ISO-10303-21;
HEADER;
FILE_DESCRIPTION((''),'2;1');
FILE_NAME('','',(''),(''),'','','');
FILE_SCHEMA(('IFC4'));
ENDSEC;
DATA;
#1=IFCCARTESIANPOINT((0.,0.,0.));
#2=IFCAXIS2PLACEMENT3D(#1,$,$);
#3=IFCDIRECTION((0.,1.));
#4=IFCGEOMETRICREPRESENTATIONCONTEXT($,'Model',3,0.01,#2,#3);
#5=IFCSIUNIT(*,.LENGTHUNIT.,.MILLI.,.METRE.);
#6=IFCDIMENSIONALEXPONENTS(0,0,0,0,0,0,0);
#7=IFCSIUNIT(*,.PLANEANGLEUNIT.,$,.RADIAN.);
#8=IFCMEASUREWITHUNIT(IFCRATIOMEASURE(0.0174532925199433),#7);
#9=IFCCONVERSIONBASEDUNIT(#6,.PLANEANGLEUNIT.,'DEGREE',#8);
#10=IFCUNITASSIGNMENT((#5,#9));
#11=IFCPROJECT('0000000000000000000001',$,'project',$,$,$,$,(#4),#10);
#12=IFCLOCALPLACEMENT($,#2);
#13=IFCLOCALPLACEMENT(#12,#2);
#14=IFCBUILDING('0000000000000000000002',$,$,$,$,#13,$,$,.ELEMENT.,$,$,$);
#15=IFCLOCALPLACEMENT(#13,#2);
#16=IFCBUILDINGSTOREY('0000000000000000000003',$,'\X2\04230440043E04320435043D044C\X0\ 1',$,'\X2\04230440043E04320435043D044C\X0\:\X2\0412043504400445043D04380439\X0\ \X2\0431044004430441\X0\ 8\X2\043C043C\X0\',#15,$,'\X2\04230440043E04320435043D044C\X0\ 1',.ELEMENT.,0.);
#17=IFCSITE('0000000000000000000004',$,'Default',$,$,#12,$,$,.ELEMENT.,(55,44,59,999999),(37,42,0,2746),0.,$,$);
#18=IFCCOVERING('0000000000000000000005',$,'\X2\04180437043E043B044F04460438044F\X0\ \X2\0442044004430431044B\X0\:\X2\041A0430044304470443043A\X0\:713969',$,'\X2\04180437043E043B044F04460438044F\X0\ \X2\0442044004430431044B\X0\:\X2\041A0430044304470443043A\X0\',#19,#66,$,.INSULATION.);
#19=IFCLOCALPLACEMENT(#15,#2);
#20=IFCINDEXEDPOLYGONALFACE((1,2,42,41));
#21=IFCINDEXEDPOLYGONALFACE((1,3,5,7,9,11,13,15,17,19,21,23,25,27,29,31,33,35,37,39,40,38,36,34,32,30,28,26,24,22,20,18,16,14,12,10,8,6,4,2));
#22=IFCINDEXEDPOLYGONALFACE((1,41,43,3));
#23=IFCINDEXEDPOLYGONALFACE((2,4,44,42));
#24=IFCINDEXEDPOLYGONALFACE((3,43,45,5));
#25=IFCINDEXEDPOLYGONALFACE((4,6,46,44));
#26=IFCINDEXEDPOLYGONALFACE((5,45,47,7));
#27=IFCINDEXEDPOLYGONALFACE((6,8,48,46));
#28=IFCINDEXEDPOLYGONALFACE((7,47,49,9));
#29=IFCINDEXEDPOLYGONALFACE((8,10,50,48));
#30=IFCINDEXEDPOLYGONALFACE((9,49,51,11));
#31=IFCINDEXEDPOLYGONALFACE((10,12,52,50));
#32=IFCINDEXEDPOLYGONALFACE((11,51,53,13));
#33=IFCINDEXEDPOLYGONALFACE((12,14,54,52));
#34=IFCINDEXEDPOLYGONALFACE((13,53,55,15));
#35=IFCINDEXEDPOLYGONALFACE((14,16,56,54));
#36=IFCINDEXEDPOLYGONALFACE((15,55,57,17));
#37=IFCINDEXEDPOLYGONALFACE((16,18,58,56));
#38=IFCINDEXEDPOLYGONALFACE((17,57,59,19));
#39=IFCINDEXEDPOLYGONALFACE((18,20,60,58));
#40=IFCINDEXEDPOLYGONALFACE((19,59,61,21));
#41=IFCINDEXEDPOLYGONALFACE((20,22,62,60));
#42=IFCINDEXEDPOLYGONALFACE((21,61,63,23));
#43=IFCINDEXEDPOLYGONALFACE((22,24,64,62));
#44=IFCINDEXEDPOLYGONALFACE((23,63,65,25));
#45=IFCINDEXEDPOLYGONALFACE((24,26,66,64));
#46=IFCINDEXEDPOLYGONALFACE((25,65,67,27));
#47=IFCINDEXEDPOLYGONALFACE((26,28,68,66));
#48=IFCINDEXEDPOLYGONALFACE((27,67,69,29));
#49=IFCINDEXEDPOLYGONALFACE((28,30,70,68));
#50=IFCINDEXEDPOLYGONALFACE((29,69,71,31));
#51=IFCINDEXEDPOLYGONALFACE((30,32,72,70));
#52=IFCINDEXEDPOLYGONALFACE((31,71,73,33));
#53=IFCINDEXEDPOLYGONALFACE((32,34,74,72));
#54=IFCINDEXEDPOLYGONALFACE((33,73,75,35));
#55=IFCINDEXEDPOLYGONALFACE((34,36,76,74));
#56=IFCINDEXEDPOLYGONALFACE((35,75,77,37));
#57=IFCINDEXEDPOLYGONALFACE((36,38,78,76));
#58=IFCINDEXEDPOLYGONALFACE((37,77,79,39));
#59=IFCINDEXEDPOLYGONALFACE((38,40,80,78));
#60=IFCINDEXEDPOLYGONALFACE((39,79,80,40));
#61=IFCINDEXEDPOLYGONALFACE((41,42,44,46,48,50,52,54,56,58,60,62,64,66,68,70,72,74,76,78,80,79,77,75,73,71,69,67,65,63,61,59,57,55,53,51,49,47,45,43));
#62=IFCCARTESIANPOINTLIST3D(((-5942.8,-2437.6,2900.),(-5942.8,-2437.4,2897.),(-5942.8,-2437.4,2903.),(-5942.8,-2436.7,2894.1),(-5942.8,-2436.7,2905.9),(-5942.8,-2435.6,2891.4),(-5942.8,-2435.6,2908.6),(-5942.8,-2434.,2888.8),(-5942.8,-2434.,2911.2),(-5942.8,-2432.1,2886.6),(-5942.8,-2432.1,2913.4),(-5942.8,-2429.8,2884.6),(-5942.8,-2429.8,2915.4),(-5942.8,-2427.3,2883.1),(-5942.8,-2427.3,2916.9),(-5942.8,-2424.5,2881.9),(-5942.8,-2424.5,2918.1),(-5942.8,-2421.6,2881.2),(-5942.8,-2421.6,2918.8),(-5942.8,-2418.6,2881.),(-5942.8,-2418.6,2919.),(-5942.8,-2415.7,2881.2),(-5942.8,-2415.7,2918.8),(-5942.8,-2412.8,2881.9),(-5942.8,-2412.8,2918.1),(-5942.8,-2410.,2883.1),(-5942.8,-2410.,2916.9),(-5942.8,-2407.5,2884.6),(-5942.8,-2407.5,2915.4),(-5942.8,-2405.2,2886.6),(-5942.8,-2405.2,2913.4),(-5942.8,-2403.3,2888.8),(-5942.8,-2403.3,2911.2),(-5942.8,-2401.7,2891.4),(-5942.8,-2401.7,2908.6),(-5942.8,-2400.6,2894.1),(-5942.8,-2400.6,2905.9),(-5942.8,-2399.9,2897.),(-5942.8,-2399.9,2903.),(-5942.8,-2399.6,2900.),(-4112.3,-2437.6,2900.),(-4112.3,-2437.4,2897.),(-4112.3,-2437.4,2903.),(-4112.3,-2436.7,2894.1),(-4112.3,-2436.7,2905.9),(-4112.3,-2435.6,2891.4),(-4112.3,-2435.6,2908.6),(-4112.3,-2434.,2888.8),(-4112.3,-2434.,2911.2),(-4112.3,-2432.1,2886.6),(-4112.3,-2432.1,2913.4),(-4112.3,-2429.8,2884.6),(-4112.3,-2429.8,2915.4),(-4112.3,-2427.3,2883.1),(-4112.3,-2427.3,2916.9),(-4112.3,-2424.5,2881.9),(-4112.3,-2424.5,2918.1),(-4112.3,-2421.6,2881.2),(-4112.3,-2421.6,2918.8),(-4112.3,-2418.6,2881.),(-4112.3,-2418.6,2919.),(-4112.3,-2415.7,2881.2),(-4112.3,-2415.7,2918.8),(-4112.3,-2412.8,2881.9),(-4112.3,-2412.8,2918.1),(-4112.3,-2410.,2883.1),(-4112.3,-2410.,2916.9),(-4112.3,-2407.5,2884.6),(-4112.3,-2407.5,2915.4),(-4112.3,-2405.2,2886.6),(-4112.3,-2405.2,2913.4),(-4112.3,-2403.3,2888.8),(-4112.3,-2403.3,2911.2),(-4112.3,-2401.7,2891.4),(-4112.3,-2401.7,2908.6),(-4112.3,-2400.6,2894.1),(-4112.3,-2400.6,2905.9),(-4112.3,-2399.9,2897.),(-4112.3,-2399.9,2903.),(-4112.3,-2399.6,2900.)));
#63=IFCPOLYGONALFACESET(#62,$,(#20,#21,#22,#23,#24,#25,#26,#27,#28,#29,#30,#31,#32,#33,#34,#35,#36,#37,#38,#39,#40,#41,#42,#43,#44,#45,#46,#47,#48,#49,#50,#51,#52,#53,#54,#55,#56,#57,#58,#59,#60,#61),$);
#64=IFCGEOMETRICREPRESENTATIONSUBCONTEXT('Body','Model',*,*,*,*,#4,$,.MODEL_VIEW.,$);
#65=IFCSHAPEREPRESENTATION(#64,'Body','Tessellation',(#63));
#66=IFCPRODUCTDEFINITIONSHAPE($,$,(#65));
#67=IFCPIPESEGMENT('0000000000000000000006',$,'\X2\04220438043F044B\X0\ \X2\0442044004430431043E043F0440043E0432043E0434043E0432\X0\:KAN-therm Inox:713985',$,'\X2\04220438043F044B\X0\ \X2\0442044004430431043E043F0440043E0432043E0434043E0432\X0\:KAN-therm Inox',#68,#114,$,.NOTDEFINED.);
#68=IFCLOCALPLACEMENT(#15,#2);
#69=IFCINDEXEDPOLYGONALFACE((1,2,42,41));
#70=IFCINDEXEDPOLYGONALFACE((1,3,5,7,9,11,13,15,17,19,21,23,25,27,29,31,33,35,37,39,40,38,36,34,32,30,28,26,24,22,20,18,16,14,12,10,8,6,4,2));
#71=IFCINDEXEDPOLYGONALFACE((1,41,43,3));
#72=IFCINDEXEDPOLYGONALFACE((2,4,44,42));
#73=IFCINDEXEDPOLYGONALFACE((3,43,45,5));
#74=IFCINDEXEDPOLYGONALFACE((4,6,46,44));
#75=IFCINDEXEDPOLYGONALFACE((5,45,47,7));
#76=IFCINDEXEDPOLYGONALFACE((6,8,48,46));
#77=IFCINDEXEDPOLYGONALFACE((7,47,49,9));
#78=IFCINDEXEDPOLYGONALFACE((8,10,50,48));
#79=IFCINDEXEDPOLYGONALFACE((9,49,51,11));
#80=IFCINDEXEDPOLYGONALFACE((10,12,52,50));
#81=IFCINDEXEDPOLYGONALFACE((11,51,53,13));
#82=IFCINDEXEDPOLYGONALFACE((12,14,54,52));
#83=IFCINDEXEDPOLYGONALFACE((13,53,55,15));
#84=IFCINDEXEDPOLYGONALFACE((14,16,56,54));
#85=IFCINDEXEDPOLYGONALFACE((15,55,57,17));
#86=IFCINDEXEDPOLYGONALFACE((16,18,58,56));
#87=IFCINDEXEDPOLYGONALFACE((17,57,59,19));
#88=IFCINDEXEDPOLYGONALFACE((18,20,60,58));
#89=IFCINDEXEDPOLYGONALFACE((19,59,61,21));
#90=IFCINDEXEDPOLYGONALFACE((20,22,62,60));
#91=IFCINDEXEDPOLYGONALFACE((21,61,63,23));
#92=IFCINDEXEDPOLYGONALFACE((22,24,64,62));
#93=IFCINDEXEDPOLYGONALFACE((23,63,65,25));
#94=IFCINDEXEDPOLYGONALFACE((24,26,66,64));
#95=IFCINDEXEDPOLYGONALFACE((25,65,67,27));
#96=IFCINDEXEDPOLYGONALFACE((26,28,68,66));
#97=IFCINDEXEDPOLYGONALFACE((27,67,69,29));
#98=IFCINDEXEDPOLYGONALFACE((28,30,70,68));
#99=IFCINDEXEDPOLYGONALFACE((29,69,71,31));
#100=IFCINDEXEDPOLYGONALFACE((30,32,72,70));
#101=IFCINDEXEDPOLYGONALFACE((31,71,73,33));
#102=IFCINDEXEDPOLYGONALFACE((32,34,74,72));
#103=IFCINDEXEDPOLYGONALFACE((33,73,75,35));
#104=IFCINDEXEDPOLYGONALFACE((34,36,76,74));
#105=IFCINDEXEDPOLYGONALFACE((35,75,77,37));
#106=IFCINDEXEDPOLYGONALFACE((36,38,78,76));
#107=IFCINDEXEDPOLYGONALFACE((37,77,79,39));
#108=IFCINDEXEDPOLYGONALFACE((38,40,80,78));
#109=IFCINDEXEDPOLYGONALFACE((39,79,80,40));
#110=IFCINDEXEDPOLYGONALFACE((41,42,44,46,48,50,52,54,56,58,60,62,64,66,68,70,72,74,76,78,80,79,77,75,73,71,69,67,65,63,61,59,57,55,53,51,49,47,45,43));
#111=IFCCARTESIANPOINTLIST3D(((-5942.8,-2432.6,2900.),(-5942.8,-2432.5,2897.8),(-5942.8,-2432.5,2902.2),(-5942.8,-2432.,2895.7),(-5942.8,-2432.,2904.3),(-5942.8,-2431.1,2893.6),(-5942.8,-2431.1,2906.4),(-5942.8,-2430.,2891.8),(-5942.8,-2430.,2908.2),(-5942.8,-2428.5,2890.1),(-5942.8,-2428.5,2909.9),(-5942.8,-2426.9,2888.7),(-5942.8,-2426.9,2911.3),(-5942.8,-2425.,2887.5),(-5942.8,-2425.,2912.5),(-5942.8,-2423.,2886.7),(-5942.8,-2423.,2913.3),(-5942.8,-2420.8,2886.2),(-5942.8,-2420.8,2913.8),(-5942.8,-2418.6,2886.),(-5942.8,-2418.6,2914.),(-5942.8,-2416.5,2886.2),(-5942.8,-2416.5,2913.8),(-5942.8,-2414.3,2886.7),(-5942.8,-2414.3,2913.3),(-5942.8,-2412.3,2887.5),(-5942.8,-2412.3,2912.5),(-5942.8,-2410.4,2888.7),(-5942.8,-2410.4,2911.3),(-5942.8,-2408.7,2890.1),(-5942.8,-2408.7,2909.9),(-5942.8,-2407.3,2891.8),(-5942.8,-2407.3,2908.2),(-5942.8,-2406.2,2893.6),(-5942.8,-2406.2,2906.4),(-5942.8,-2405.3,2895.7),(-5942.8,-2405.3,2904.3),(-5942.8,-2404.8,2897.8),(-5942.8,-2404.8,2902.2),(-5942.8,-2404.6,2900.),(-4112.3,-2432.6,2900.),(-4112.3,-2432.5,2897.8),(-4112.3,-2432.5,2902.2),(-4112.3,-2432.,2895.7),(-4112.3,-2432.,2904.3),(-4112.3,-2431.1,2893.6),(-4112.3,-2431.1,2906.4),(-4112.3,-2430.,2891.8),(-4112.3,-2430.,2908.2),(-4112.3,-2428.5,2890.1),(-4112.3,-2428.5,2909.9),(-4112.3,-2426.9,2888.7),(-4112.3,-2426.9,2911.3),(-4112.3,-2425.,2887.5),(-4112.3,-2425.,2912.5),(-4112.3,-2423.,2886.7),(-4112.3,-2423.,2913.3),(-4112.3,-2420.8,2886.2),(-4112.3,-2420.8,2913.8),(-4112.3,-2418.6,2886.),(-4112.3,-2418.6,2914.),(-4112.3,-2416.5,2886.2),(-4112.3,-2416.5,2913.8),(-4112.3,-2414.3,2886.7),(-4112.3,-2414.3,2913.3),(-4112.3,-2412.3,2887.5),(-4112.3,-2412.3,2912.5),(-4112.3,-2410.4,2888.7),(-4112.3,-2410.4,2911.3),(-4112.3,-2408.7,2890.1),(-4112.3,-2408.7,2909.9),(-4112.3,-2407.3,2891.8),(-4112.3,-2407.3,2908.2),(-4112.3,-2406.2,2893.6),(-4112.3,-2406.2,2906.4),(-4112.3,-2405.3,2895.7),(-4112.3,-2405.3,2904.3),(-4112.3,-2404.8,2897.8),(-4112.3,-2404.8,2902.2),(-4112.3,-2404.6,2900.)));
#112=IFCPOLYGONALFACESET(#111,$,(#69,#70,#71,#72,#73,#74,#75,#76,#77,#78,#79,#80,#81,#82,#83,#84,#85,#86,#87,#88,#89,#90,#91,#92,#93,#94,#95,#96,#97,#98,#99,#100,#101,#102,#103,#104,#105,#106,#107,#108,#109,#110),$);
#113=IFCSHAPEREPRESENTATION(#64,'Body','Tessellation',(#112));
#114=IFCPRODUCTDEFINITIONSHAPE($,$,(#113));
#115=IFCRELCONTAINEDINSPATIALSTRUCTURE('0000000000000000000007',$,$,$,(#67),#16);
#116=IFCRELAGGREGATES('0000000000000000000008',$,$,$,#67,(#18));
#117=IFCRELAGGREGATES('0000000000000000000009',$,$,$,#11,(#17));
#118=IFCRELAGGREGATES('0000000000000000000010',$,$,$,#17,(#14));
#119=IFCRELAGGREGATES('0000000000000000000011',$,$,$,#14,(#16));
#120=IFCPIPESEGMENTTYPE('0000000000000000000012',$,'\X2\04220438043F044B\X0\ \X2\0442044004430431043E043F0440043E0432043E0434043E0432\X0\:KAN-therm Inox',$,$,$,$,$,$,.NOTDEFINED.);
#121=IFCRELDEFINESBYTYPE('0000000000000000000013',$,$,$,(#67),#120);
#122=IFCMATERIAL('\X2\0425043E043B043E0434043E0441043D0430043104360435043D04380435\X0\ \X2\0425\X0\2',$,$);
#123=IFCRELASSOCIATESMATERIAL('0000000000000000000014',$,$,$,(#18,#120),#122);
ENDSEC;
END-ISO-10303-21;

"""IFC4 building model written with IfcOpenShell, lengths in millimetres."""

from ifc_helpers import new_model, entity, si_unit, converted_unit, direction, frame, origin, place, context, subcontext, project, spatial, indexed_curve, outline, extrude, material, type_object, element, aggregate, save


model = new_model("IFC4")

# Units and contexts
model_context = context("Model", 3, precision=0.01, world=origin(), true_north=direction((0.0, 1.0)))
body_context = subcontext(model_context, "Body", "Model", "MODEL_VIEW")
ifc_project = project(units=[si_unit("LENGTHUNIT", "METRE", prefix="MILLI"), converted_unit("PLANEANGLEUNIT", "DEGREE", entity("IfcRatioMeasure", 0.0174532925199433), si_unit("PLANEANGLEUNIT", "RADIAN"), dimensions=[0, 0, 0, 0, 0, 0, 0])], contexts=[model_context])

# Site, building, storey
site_placement = place(None, origin())
site = spatial("IfcSite", under=ifc_project, at=site_placement, Name="Default", CompositionType="ELEMENT", RefLatitude=(55, 44, 59, 999999), RefLongitude=(37, 42, 0, 2746), RefElevation=0.0)
building_placement = place(site_placement, origin())
building = spatial("IfcBuilding", under=site, at=building_placement, CompositionType="ELEMENT")
storey_placement = place(building_placement, origin())
storey = spatial("IfcBuildingStorey", under=building, at=storey_placement, Name="Уровень 1", ObjectType="Уровень:Верхний брус 8мм", LongName="Уровень 1", CompositionType="ELEMENT", Elevation=0.0)

# Covering
ifc_material_1 = material(Name="Холодоснабжение Х2")
covering_1_placement = place(storey_placement, origin())
covering_1 = element("IfcCovering", 1, at=covering_1_placement, material=ifc_material_1, Name="Изоляция трубы:Каучук:713969", ObjectType="Изоляция трубы:Каучук", PredefinedType="INSULATION", context=body_context, shape_type="SweptSolid", body=[
    extrude(outline(indexed_curve([(19.0, 0.0), (18.8, 3.0), (18.1, 5.9), (16.9, 8.6), (15.4, 11.2), (13.4, 13.4), (11.2, 15.4), (8.6, 16.9), (5.9, 18.1), (3.0, 18.8), (0.0, 19.0), (-3.0, 18.8), (-5.9, 18.1), (-8.6, 16.9), (-11.2, 15.4), (-13.4, 13.4), (-15.4, 11.2), (-16.9, 8.6), (-18.1, 5.9), (-18.8, 3.0), (-19.0, 0.0), (-18.8, -3.0), (-18.1, -5.9), (-16.9, -8.6), (-15.4, -11.2), (-13.4, -13.4), (-11.2, -15.4), (-8.6, -16.9), (-5.9, -18.1), (-3.0, -18.8), (0.0, -19.0), (3.0, -18.8), (5.9, -18.1), (8.6, -16.9), (11.2, -15.4), (13.4, -13.4), (15.4, -11.2), (16.9, -8.6), (18.1, -5.9), (18.8, -3.0), (19.0, 0.0)], self_intersect=False)), frame((-5942.8, -2418.6, 2900.0), z_axis=(1.0, 0.0, 0.0), x_axis=(0.0, -1.0, 0.0)), (0.0, 0.0, 1.0), 1830.4),
])

# Pipe segment
pipe_segment_type_1 = type_object("IfcPipeSegmentType", Name="Типы трубопроводов:KAN-therm Inox", PredefinedType="NOTDEFINED", material=ifc_material_1)
pipe_segment_1_placement = place(storey_placement, origin())
pipe_segment_1 = element("IfcPipeSegment", 2, at=pipe_segment_1_placement, inside=storey, type_object=pipe_segment_type_1, Name="Типы трубопроводов:KAN-therm Inox:713985", ObjectType="Типы трубопроводов:KAN-therm Inox", PredefinedType="NOTDEFINED", context=body_context, shape_type="SweptSolid", body=[
    extrude(outline(indexed_curve([(14.0, 0.0), (13.8, 2.2), (13.3, 4.3), (12.5, 6.4), (11.3, 8.2), (9.9, 9.9), (8.2, 11.3), (6.4, 12.5), (4.3, 13.3), (2.2, 13.8), (0.0, 14.0), (-2.2, 13.8), (-4.3, 13.3), (-6.4, 12.5), (-8.2, 11.3), (-9.9, 9.9), (-11.3, 8.2), (-12.5, 6.4), (-13.3, 4.3), (-13.8, 2.2), (-14.0, 0.0), (-13.8, -2.2), (-13.3, -4.3), (-12.5, -6.4), (-11.3, -8.2), (-9.9, -9.9), (-8.2, -11.3), (-6.4, -12.5), (-4.3, -13.3), (-2.2, -13.8), (0.0, -14.0), (2.2, -13.8), (4.3, -13.3), (6.4, -12.5), (8.2, -11.3), (9.9, -9.9), (11.3, -8.2), (12.5, -6.4), (13.3, -4.3), (13.8, -2.2), (14.0, 0.0)], self_intersect=False)), frame((-5942.8, -2418.6, 2900.0), z_axis=(1.0, 0.0, 0.0), x_axis=(0.0, 1.0, 0.0)), (0.0, 0.0, 1.0), 1830.4),
])
aggregate(pipe_segment_1, [covering_1])

save(model, "model.ifc")
